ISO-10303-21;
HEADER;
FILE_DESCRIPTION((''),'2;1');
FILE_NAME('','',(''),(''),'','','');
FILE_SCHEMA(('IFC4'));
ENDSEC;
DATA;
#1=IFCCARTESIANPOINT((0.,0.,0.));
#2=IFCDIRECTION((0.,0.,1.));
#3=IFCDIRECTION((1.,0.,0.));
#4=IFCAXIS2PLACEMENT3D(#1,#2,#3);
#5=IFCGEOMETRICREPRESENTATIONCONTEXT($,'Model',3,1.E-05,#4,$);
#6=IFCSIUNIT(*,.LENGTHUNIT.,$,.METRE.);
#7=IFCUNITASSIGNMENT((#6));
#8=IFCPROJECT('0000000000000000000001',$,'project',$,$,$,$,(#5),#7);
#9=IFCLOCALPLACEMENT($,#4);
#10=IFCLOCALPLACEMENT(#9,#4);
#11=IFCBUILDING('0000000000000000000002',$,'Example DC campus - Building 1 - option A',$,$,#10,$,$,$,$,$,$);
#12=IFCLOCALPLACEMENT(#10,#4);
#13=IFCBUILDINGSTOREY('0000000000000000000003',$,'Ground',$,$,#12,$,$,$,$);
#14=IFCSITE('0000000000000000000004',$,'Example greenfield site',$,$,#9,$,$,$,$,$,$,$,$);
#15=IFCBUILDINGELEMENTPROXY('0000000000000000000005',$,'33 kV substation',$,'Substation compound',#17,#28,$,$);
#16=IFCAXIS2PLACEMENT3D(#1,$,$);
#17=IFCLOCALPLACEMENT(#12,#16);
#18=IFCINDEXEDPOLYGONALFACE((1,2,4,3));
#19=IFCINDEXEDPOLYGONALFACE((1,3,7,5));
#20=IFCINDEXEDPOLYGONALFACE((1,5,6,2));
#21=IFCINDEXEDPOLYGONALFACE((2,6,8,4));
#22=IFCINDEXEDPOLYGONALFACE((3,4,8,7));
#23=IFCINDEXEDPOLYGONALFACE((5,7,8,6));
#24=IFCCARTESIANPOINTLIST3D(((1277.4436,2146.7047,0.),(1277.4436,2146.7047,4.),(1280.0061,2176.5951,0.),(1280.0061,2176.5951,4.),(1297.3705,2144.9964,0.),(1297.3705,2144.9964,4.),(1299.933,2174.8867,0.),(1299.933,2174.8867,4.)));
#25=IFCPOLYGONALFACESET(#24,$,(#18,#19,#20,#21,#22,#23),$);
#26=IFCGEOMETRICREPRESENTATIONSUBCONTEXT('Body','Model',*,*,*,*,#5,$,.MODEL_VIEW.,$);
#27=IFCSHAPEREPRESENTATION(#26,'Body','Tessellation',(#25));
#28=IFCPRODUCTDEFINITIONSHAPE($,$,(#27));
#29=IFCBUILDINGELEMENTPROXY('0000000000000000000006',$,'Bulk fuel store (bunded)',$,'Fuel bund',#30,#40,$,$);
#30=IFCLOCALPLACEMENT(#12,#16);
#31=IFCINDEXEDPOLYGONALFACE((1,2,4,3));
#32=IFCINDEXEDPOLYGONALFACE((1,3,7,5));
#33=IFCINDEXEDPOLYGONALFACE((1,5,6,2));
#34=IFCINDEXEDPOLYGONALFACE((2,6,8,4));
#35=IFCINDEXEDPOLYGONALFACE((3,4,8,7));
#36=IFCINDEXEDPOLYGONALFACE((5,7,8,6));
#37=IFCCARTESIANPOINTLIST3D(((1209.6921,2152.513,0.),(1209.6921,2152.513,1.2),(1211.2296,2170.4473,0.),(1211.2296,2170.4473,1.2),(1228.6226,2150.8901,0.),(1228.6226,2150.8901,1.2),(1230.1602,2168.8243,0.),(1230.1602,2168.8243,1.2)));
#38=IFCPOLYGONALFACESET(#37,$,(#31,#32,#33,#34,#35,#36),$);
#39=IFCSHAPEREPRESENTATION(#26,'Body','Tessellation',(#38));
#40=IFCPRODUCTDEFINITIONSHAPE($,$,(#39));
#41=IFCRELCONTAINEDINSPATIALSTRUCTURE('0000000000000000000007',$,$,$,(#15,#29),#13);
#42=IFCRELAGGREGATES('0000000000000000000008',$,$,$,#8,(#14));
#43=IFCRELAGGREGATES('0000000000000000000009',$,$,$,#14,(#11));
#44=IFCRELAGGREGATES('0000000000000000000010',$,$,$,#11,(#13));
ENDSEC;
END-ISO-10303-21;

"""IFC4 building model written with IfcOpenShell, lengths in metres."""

from ifc_helpers import new_model, si_unit, frame, origin_with_axes, place, context, subcontext, project, spatial, line, indexed_curve, outline, extrude, element, save


model = new_model("IFC4")

# Units and contexts
model_context = context("Model", 3, precision=1e-05, world=origin_with_axes())
body_context = subcontext(model_context, "Body", "Model", "MODEL_VIEW")
ifc_project = project(units=[si_unit("LENGTHUNIT", "METRE")], contexts=[model_context])

# Site, building, storey
site_placement = place(None, origin_with_axes())
site = spatial("IfcSite", under=ifc_project, at=site_placement, Name="Example greenfield site")
building_placement = place(site_placement, origin_with_axes())
building = spatial("IfcBuilding", under=site, at=building_placement, Name="Example DC campus - Building 1 - option A")
storey_placement = place(building_placement, origin_with_axes())
storey = spatial("IfcBuildingStorey", under=building, at=storey_placement, Name="Ground")

# Building element proxies
proxy_1_placement = place(storey_placement, frame((1277.4436, 2146.7047, 0.0), z_axis=(0.0, 0.0, 1.0), x_axis=(0.996345, -0.085417, 0.0)))
element("IfcBuildingElementProxy", 1, at=proxy_1_placement, inside=storey, Name="33 kV substation", ObjectType="Substation compound", context=body_context, shape_type="SweptSolid", body=[
    extrude(outline(indexed_curve([(0.0, 0.0), (20.0, 0.0), (20.0, 30.0), (0.0, 30.0)], segments=[line(1, 2, 3, 4, 1)])), origin_with_axes(), (0.0, 0.0, 1.0), 4.0),
])
proxy_2_placement = place(storey_placement, frame((1209.6921, 2152.513, 0.0), z_axis=(0.0, 0.0, 1.0), x_axis=(0.996345, -0.085417, 0.0)))
element("IfcBuildingElementProxy", 2, at=proxy_2_placement, inside=storey, Name="Bulk fuel store (bunded)", ObjectType="Fuel bund", context=body_context, shape_type="SweptSolid", body=[
    extrude(outline(indexed_curve([(0.0, 0.0), (19.0, 0.0), (19.0, 18.0), (0.0, 18.0)], segments=[line(1, 2, 3, 4, 1)])), origin_with_axes(), (0.0, 0.0, 1.0), 1.2),
])

save(model, "model.ifc")
